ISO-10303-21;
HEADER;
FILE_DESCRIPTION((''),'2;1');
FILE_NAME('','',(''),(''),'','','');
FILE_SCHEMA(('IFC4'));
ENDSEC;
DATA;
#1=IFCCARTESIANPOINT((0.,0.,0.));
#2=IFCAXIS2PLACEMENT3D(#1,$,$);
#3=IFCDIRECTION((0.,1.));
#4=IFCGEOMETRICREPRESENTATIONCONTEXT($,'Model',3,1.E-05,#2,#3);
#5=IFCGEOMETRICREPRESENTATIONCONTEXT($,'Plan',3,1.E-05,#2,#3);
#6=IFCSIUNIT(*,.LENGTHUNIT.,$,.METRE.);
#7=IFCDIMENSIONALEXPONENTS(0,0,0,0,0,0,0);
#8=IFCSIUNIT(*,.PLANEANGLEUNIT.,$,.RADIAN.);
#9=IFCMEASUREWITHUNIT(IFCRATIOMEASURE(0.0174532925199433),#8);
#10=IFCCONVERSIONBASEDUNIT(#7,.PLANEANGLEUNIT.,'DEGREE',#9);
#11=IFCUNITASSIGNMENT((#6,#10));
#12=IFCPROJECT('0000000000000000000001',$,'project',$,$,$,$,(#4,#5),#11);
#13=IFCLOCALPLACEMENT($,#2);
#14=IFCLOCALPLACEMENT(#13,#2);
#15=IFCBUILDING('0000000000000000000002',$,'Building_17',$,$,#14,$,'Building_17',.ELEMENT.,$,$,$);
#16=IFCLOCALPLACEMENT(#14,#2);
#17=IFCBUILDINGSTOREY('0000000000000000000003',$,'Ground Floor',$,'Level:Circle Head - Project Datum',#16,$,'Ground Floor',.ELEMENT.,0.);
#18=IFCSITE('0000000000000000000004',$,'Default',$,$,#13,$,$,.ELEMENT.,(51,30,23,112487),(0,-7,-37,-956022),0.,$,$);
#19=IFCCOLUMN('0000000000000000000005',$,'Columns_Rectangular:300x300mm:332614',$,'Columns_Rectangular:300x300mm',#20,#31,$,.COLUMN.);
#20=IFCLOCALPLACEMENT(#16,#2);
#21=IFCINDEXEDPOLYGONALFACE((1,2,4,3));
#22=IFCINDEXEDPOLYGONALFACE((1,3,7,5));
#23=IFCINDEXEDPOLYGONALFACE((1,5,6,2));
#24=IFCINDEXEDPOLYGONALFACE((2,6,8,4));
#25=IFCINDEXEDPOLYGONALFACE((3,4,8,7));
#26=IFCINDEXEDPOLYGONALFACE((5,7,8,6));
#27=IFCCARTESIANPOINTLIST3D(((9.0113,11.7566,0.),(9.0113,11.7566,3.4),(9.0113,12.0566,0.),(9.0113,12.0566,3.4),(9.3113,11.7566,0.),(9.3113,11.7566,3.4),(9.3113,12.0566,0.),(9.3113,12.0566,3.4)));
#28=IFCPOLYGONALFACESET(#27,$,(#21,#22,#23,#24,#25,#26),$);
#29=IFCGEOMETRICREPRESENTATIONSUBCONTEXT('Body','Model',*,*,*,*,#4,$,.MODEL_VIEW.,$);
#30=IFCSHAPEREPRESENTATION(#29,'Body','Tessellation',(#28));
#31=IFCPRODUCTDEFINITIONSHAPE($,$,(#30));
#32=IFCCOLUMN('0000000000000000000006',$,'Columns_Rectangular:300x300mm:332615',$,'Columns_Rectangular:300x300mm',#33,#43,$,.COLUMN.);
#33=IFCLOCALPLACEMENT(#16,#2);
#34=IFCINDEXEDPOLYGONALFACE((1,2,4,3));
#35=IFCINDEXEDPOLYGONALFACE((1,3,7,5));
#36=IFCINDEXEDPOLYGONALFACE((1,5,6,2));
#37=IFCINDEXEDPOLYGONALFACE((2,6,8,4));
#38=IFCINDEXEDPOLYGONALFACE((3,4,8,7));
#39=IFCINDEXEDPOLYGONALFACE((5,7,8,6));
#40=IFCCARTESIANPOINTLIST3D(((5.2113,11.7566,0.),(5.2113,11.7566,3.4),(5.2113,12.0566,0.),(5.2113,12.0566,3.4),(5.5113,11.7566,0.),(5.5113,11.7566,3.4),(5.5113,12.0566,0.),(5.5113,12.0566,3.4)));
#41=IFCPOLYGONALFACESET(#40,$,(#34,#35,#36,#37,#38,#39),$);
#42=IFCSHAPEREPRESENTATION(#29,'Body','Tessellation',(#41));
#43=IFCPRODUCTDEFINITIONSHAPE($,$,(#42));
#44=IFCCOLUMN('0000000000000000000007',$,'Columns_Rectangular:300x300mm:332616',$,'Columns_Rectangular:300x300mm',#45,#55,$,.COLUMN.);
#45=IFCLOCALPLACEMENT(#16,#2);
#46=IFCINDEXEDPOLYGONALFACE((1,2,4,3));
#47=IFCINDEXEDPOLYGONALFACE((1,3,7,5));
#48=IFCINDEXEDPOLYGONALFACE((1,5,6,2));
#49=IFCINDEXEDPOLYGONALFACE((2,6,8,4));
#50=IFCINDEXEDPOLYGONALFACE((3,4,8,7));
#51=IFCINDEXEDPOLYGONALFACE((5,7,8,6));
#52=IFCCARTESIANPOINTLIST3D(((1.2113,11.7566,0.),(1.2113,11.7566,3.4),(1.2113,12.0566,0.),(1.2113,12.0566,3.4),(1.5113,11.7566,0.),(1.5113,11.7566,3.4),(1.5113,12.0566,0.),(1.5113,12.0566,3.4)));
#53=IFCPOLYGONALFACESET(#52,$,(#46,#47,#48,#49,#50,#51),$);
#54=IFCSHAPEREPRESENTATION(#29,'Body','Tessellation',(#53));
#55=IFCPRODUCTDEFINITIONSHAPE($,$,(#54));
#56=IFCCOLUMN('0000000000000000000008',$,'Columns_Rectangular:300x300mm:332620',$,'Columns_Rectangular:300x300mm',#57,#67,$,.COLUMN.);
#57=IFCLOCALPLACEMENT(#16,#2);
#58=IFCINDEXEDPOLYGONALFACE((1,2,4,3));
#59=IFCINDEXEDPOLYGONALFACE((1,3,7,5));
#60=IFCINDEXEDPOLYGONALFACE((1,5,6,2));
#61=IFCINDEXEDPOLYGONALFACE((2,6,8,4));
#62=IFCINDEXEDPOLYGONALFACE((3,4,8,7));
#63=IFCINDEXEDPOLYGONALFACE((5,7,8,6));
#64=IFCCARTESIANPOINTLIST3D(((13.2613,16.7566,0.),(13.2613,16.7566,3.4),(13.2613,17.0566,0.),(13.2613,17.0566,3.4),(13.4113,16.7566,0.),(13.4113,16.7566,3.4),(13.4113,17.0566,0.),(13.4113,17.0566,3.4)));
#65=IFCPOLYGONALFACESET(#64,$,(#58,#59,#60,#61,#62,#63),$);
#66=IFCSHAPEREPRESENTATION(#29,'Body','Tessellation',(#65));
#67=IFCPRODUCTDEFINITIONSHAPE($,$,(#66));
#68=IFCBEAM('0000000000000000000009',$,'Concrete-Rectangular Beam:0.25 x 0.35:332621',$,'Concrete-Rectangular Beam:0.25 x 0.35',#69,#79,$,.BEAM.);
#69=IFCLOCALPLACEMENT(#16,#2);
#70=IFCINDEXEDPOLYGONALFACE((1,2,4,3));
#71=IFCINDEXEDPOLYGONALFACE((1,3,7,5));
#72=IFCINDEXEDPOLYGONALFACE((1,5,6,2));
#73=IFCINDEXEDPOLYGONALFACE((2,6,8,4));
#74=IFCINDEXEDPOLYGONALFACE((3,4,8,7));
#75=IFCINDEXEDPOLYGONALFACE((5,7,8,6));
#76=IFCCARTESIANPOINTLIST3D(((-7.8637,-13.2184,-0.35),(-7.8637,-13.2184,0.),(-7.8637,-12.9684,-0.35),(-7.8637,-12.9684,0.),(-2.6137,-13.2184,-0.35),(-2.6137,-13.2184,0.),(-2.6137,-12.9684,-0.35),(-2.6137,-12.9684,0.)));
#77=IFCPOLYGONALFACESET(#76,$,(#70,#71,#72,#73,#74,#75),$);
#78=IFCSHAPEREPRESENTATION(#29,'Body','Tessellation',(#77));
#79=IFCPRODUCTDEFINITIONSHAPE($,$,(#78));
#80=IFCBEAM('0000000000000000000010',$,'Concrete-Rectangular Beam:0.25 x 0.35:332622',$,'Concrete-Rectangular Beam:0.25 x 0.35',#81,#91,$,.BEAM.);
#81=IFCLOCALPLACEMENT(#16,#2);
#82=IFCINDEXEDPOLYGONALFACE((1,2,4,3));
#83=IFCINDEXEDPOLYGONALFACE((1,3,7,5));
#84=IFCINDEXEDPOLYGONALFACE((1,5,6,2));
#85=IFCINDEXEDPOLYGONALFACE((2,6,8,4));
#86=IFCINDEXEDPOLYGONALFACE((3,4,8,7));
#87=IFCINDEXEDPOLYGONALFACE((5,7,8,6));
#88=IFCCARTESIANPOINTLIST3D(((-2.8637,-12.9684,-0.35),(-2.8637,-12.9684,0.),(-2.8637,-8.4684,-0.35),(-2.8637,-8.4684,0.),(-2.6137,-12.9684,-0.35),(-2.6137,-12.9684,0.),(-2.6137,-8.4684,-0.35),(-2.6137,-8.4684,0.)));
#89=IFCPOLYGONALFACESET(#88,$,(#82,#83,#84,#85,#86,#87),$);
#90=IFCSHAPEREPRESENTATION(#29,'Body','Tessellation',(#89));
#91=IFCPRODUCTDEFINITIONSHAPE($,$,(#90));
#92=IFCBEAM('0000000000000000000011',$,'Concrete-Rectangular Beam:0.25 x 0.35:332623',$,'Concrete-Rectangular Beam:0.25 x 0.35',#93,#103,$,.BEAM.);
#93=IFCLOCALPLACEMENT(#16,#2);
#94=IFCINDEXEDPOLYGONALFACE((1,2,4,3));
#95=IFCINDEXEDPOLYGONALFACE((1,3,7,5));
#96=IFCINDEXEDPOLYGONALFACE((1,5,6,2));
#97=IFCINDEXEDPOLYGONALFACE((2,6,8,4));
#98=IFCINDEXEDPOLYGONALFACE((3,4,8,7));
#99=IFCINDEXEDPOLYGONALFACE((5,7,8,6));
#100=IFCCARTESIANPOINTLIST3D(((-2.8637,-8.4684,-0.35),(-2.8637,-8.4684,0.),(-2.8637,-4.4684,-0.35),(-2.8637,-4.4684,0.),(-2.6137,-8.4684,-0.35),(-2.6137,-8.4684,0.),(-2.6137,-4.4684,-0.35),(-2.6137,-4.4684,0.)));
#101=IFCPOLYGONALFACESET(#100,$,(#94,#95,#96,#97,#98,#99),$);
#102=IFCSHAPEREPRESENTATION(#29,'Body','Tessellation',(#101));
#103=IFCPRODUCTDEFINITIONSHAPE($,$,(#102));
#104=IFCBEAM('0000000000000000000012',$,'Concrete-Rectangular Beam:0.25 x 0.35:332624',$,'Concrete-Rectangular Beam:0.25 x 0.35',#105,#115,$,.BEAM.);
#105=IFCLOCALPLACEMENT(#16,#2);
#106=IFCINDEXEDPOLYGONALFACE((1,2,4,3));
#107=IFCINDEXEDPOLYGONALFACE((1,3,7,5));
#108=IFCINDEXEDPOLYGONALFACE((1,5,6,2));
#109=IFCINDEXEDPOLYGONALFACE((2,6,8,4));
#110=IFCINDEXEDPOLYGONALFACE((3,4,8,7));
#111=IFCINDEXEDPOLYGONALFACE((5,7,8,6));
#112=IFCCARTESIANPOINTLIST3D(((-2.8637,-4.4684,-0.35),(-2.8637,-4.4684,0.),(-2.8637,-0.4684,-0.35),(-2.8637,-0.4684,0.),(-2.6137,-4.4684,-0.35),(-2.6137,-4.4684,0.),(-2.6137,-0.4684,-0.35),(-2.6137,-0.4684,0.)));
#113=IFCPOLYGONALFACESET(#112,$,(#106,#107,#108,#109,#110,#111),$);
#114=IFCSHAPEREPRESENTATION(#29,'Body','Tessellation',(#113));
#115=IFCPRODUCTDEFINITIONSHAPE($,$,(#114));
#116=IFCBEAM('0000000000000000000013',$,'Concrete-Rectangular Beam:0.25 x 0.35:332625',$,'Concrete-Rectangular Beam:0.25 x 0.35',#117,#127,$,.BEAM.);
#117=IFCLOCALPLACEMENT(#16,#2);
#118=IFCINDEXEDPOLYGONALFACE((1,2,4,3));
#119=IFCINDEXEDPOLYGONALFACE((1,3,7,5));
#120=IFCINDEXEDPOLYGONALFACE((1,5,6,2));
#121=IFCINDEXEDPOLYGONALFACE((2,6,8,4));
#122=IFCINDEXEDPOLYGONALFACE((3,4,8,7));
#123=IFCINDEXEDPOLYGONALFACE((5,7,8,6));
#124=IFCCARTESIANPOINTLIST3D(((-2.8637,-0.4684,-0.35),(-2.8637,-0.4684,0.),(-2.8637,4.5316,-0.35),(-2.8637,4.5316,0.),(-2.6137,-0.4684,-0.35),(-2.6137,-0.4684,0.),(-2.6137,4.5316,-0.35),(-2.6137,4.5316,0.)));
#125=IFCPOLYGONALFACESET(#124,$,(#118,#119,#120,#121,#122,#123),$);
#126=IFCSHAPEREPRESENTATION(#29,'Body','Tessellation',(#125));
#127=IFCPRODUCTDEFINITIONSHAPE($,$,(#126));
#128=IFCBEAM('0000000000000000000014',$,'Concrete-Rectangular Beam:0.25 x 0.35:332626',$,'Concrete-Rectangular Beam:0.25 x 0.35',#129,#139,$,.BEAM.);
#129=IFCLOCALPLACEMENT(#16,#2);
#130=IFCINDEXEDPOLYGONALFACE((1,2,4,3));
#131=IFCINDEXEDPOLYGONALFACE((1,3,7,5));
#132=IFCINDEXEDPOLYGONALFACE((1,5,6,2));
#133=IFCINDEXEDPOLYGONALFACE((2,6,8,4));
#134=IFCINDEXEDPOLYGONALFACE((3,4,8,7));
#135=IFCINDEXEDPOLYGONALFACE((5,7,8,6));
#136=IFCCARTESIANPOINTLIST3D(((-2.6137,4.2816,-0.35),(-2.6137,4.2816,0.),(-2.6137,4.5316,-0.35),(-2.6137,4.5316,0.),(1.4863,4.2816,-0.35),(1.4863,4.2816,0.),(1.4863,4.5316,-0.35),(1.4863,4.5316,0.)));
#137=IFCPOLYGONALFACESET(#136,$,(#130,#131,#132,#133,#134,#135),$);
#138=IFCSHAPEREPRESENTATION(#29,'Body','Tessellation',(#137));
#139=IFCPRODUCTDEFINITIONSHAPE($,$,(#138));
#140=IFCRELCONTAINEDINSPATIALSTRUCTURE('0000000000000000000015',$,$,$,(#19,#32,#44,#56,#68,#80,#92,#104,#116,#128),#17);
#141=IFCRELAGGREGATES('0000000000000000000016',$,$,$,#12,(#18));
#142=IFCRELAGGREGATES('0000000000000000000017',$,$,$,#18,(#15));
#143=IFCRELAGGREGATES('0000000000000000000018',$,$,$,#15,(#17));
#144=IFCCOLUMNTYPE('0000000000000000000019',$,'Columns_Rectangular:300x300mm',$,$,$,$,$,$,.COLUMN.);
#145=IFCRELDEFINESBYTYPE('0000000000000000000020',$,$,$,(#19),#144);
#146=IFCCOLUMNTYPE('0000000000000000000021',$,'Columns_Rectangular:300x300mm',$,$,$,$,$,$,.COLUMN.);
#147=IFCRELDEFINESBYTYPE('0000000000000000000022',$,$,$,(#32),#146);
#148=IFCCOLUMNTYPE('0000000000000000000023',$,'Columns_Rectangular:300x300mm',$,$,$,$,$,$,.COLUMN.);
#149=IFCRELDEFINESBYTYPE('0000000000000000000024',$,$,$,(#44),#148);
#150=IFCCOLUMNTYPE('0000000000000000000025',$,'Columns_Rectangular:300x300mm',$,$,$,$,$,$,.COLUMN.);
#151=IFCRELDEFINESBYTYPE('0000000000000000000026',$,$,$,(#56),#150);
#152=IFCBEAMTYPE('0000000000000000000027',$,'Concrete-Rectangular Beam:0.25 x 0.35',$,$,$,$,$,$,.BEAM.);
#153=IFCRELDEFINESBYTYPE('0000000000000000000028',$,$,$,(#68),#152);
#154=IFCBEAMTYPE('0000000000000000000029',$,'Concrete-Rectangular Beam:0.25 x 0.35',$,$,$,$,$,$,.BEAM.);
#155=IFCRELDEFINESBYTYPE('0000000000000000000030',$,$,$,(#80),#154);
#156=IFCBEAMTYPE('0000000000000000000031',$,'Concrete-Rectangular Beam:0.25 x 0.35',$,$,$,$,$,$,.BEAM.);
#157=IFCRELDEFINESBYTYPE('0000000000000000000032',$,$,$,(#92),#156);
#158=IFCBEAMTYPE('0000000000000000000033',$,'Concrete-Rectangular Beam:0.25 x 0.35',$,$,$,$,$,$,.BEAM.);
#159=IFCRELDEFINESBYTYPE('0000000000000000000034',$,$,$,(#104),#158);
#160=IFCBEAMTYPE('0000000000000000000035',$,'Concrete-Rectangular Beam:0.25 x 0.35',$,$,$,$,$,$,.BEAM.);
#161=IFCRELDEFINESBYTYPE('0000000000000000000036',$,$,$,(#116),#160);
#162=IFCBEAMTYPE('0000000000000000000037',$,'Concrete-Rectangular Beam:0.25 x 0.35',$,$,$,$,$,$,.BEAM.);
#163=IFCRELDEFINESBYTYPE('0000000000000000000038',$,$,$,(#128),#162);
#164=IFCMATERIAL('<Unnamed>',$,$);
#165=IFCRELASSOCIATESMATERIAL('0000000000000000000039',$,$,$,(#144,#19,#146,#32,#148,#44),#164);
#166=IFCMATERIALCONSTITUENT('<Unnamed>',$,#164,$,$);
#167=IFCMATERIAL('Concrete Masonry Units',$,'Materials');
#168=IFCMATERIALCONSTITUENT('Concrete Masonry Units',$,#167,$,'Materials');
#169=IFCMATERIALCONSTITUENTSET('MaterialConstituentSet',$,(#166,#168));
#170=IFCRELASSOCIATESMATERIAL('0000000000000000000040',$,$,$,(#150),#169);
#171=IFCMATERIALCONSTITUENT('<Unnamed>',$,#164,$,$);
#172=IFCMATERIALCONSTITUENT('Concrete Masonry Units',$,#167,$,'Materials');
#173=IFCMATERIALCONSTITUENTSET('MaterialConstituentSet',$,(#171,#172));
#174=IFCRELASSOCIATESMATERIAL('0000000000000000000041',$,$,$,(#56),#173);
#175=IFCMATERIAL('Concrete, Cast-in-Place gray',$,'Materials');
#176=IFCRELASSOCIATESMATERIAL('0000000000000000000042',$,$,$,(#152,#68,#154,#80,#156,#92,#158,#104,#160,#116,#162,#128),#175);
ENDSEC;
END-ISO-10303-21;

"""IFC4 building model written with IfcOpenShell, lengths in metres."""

from ifc_helpers import new_model, entity, si_unit, converted_unit, direction, frame, origin, place, context, subcontext, project, spatial, indexed_curve, outline, extrude, source, transform, mapped, material, constituent, constituent_set, type_object, type_shapes, element, save


model = new_model("IFC4")

# Units and contexts
model_context = context("Model", 3, precision=1e-05, world=origin(), true_north=direction((0.0, 1.0)))
plan_context = context("Plan", 3, precision=1e-05, world=origin(), true_north=direction((0.0, 1.0)))
body_context = subcontext(model_context, "Body", "Model", "MODEL_VIEW")
ifc_project = project(units=[si_unit("LENGTHUNIT", "METRE"), converted_unit("PLANEANGLEUNIT", "DEGREE", entity("IfcRatioMeasure", 0.0174532925199433), si_unit("PLANEANGLEUNIT", "RADIAN"), dimensions=[0, 0, 0, 0, 0, 0, 0])], contexts=[model_context, plan_context])

# Site, building, storey
site_placement = place(None, origin())
site = spatial("IfcSite", under=ifc_project, at=site_placement, Name="Default", CompositionType="ELEMENT", RefLatitude=(51, 30, 23, 112487), RefLongitude=(0, -7, -37, -956022), RefElevation=0.0)
building_placement = place(site_placement, origin())
building = spatial("IfcBuilding", under=site, at=building_placement, Name="Building_17", LongName="Building_17", CompositionType="ELEMENT")
storey_placement = place(building_placement, origin())
storey = spatial("IfcBuildingStorey", under=building, at=storey_placement, Name="Ground Floor", ObjectType="Level:Circle Head - Project Datum", LongName="Ground Floor", CompositionType="ELEMENT", Elevation=0.0)

# Columns
ifc_material_1 = material(Name="<Unnamed>")
ifc_material_2 = material(Name="Concrete Masonry Units", Category="Materials")
column_type_1 = type_object("IfcColumnType", Name="Columns_Rectangular:300x300mm", PredefinedType="COLUMN", material=ifc_material_1)
shared_shape_1 = source(origin(), body_context, "Body", "SweptSolid", [
    extrude(outline(indexed_curve([(-0.15, -0.15), (0.15, -0.15), (0.15, 0.15), (-0.15, 0.15), (-0.15, -0.15)], self_intersect=False)), frame((9.1613, 11.9066, 0.0), z_axis=(0.0, 0.0, 1.0), x_axis=(0.0, -1.0, 0.0)), (0.0, 0.0, 1.0), 3.4),
])
type_shapes(column_type_1, [shared_shape_1])
column_1_placement = place(storey_placement, origin())
element("IfcColumn", 1, at=column_1_placement, inside=storey, type_object=column_type_1, material=ifc_material_1, Name="Columns_Rectangular:300x300mm:332614", ObjectType="Columns_Rectangular:300x300mm", PredefinedType="COLUMN", context=body_context, shape_type="MappedRepresentation", body=[
    mapped(shared_shape_1, transform((0.0, 0.0, 0.0), scale=1.0)),
])
column_type_2 = type_object("IfcColumnType", Name="Columns_Rectangular:300x300mm", PredefinedType="COLUMN", material=ifc_material_1)
shared_shape_2 = source(origin(), body_context, "Body", "SweptSolid", [
    extrude(outline(indexed_curve([(-0.15, -0.15), (0.15, -0.15), (0.15, 0.15), (-0.15, 0.15), (-0.15, -0.15)], self_intersect=False)), frame((5.3613, 11.9066, 0.0), z_axis=(0.0, 0.0, 1.0), x_axis=(0.0, -1.0, 0.0)), (0.0, 0.0, 1.0), 3.4),
])
type_shapes(column_type_2, [shared_shape_2])
column_2_placement = place(storey_placement, origin())
element("IfcColumn", 2, at=column_2_placement, inside=storey, type_object=column_type_2, material=ifc_material_1, Name="Columns_Rectangular:300x300mm:332615", ObjectType="Columns_Rectangular:300x300mm", PredefinedType="COLUMN", context=body_context, shape_type="MappedRepresentation", body=[
    mapped(shared_shape_2, transform((0.0, 0.0, 0.0), scale=1.0)),
])
column_type_3 = type_object("IfcColumnType", Name="Columns_Rectangular:300x300mm", PredefinedType="COLUMN", material=ifc_material_1)
shared_shape_3 = source(origin(), body_context, "Body", "SweptSolid", [
    extrude(outline(indexed_curve([(-0.15, -0.15), (0.15, -0.15), (0.15, 0.15), (-0.15, 0.15), (-0.15, -0.15)], self_intersect=False)), frame((1.3613, 11.9066, 0.0), z_axis=(0.0, 0.0, 1.0), x_axis=(0.0, -1.0, 0.0)), (0.0, 0.0, 1.0), 3.4),
])
type_shapes(column_type_3, [shared_shape_3])
column_3_placement = place(storey_placement, origin())
element("IfcColumn", 3, at=column_3_placement, inside=storey, type_object=column_type_3, material=ifc_material_1, Name="Columns_Rectangular:300x300mm:332616", ObjectType="Columns_Rectangular:300x300mm", PredefinedType="COLUMN", context=body_context, shape_type="MappedRepresentation", body=[
    mapped(shared_shape_3, transform((0.0, 0.0, 0.0), scale=1.0)),
])
ifc_constituent_1 = constituent(ifc_material_1, Name="<Unnamed>")
ifc_constituent_2 = constituent(ifc_material_2, Name="Concrete Masonry Units", Category="Materials")
ifc_constituent_set_1 = constituent_set(constituents=[ifc_constituent_1, ifc_constituent_2], Name="MaterialConstituentSet")
ifc_constituent_3 = constituent(ifc_material_1, Name="<Unnamed>")
ifc_constituent_4 = constituent(ifc_material_2, Name="Concrete Masonry Units", Category="Materials")
ifc_constituent_set_2 = constituent_set(constituents=[ifc_constituent_3, ifc_constituent_4], Name="MaterialConstituentSet")
column_type_4 = type_object("IfcColumnType", Name="Columns_Rectangular:300x300mm", PredefinedType="COLUMN", material=ifc_constituent_set_2)
shared_shape_4 = source(origin(), body_context, "Body", "SweptSolid", [
    extrude(outline(indexed_curve([(-0.15, -0.075), (0.15, -0.075), (0.15, 0.075), (-0.15, 0.075), (-0.15, -0.075)], self_intersect=False)), frame((13.3363, 16.9066, 0.0), z_axis=(0.0, 0.0, 1.0), x_axis=(0.0, -1.0, 0.0)), (0.0, 0.0, 1.0), 3.4),
])
type_shapes(column_type_4, [shared_shape_4])
column_4_placement = place(storey_placement, origin())
element("IfcColumn", 4, at=column_4_placement, inside=storey, type_object=column_type_4, material=ifc_constituent_set_1, Name="Columns_Rectangular:300x300mm:332620", ObjectType="Columns_Rectangular:300x300mm", PredefinedType="COLUMN", context=body_context, shape_type="MappedRepresentation", body=[
    mapped(shared_shape_4, transform((0.0, 0.0, 0.0), scale=1.0)),
])

# Beams
ifc_material_3 = material(Name="Concrete, Cast-in-Place gray", Category="Materials")
beam_type_1 = type_object("IfcBeamType", Name="Concrete-Rectangular Beam:0.25 x 0.35", PredefinedType="BEAM", material=ifc_material_3)
shared_shape_5 = source(origin(), body_context, "Body", "SweptSolid", [
    extrude(outline(indexed_curve([(-0.175, -0.125), (0.175, -0.125), (0.175, 0.125), (-0.175, 0.125), (-0.175, -0.125)], self_intersect=False)), frame((-7.8637, -13.0934, -0.175), z_axis=(1.0, 0.0, 0.0), x_axis=(0.0, 0.0, -1.0)), (0.0, 0.0, 1.0), 5.25),
])
type_shapes(beam_type_1, [shared_shape_5])
beam_1_placement = place(storey_placement, origin())
element("IfcBeam", 5, at=beam_1_placement, inside=storey, type_object=beam_type_1, material=ifc_material_3, Name="Concrete-Rectangular Beam:0.25 x 0.35:332621", ObjectType="Concrete-Rectangular Beam:0.25 x 0.35", PredefinedType="BEAM", context=body_context, shape_type="MappedRepresentation", body=[
    mapped(shared_shape_5, transform((0.0, 0.0, 0.0), scale=1.0)),
])
beam_type_2 = type_object("IfcBeamType", Name="Concrete-Rectangular Beam:0.25 x 0.35", PredefinedType="BEAM", material=ifc_material_3)
shared_shape_6 = source(origin(), body_context, "Body", "SweptSolid", [
    extrude(outline(indexed_curve([(-0.125, -0.175), (0.125, -0.175), (0.125, 0.175), (-0.125, 0.175), (-0.125, -0.175)], self_intersect=False)), frame((-2.7387, -12.9684, -0.175), z_axis=(0.0, 1.0, 0.0), x_axis=(-1.0, 0.0, 0.0)), (0.0, 0.0, 1.0), 4.5),
])
type_shapes(beam_type_2, [shared_shape_6])
beam_2_placement = place(storey_placement, origin())
element("IfcBeam", 6, at=beam_2_placement, inside=storey, type_object=beam_type_2, material=ifc_material_3, Name="Concrete-Rectangular Beam:0.25 x 0.35:332622", ObjectType="Concrete-Rectangular Beam:0.25 x 0.35", PredefinedType="BEAM", context=body_context, shape_type="MappedRepresentation", body=[
    mapped(shared_shape_6, transform((0.0, 0.0, 0.0), scale=1.0)),
])
beam_type_3 = type_object("IfcBeamType", Name="Concrete-Rectangular Beam:0.25 x 0.35", PredefinedType="BEAM", material=ifc_material_3)
shared_shape_7 = source(origin(), body_context, "Body", "SweptSolid", [
    extrude(outline(indexed_curve([(-0.125, -0.175), (0.125, -0.175), (0.125, 0.175), (-0.125, 0.175), (-0.125, -0.175)], self_intersect=False)), frame((-2.7387, -8.4684, -0.175), z_axis=(0.0, 1.0, 0.0), x_axis=(-1.0, 0.0, 0.0)), (0.0, 0.0, 1.0), 4.0),
])
type_shapes(beam_type_3, [shared_shape_7])
beam_3_placement = place(storey_placement, origin())
element("IfcBeam", 7, at=beam_3_placement, inside=storey, type_object=beam_type_3, material=ifc_material_3, Name="Concrete-Rectangular Beam:0.25 x 0.35:332623", ObjectType="Concrete-Rectangular Beam:0.25 x 0.35", PredefinedType="BEAM", context=body_context, shape_type="MappedRepresentation", body=[
    mapped(shared_shape_7, transform((0.0, 0.0, 0.0), scale=1.0)),
])
beam_type_4 = type_object("IfcBeamType", Name="Concrete-Rectangular Beam:0.25 x 0.35", PredefinedType="BEAM", material=ifc_material_3)
shared_shape_8 = source(origin(), body_context, "Body", "SweptSolid", [
    extrude(outline(indexed_curve([(-0.125, -0.175), (0.125, -0.175), (0.125, 0.175), (-0.125, 0.175), (-0.125, -0.175)], self_intersect=False)), frame((-2.7387, -4.4684, -0.175), z_axis=(0.0, 1.0, 0.0), x_axis=(-1.0, 0.0, 0.0)), (0.0, 0.0, 1.0), 4.0),
])
type_shapes(beam_type_4, [shared_shape_8])
beam_4_placement = place(storey_placement, origin())
element("IfcBeam", 8, at=beam_4_placement, inside=storey, type_object=beam_type_4, material=ifc_material_3, Name="Concrete-Rectangular Beam:0.25 x 0.35:332624", ObjectType="Concrete-Rectangular Beam:0.25 x 0.35", PredefinedType="BEAM", context=body_context, shape_type="MappedRepresentation", body=[
    mapped(shared_shape_8, transform((0.0, 0.0, 0.0), scale=1.0)),
])
beam_type_5 = type_object("IfcBeamType", Name="Concrete-Rectangular Beam:0.25 x 0.35", PredefinedType="BEAM", material=ifc_material_3)
shared_shape_9 = source(origin(), body_context, "Body", "SweptSolid", [
    extrude(outline(indexed_curve([(-0.125, -0.175), (0.125, -0.175), (0.125, 0.175), (-0.125, 0.175), (-0.125, -0.175)], self_intersect=False)), frame((-2.7387, -0.4684, -0.175), z_axis=(0.0, 1.0, 0.0), x_axis=(-1.0, 0.0, 0.0)), (0.0, 0.0, 1.0), 5.0),
])
type_shapes(beam_type_5, [shared_shape_9])
beam_5_placement = place(storey_placement, origin())
element("IfcBeam", 9, at=beam_5_placement, inside=storey, type_object=beam_type_5, material=ifc_material_3, Name="Concrete-Rectangular Beam:0.25 x 0.35:332625", ObjectType="Concrete-Rectangular Beam:0.25 x 0.35", PredefinedType="BEAM", context=body_context, shape_type="MappedRepresentation", body=[
    mapped(shared_shape_9, transform((0.0, 0.0, 0.0), scale=1.0)),
])
beam_type_6 = type_object("IfcBeamType", Name="Concrete-Rectangular Beam:0.25 x 0.35", PredefinedType="BEAM", material=ifc_material_3)
shared_shape_10 = source(origin(), body_context, "Body", "SweptSolid", [
    extrude(outline(indexed_curve([(-0.175, -0.125), (0.175, -0.125), (0.175, 0.125), (-0.175, 0.125), (-0.175, -0.125)], self_intersect=False)), frame((-2.6137, 4.4066, -0.175), z_axis=(1.0, 0.0, 0.0), x_axis=(0.0, 0.0, -1.0)), (0.0, 0.0, 1.0), 4.1),
])
type_shapes(beam_type_6, [shared_shape_10])
beam_6_placement = place(storey_placement, origin())
element("IfcBeam", 10, at=beam_6_placement, inside=storey, type_object=beam_type_6, material=ifc_material_3, Name="Concrete-Rectangular Beam:0.25 x 0.35:332626", ObjectType="Concrete-Rectangular Beam:0.25 x 0.35", PredefinedType="BEAM", context=body_context, shape_type="MappedRepresentation", body=[
    mapped(shared_shape_10, transform((0.0, 0.0, 0.0), scale=1.0)),
])

save(model, "model.ifc")
